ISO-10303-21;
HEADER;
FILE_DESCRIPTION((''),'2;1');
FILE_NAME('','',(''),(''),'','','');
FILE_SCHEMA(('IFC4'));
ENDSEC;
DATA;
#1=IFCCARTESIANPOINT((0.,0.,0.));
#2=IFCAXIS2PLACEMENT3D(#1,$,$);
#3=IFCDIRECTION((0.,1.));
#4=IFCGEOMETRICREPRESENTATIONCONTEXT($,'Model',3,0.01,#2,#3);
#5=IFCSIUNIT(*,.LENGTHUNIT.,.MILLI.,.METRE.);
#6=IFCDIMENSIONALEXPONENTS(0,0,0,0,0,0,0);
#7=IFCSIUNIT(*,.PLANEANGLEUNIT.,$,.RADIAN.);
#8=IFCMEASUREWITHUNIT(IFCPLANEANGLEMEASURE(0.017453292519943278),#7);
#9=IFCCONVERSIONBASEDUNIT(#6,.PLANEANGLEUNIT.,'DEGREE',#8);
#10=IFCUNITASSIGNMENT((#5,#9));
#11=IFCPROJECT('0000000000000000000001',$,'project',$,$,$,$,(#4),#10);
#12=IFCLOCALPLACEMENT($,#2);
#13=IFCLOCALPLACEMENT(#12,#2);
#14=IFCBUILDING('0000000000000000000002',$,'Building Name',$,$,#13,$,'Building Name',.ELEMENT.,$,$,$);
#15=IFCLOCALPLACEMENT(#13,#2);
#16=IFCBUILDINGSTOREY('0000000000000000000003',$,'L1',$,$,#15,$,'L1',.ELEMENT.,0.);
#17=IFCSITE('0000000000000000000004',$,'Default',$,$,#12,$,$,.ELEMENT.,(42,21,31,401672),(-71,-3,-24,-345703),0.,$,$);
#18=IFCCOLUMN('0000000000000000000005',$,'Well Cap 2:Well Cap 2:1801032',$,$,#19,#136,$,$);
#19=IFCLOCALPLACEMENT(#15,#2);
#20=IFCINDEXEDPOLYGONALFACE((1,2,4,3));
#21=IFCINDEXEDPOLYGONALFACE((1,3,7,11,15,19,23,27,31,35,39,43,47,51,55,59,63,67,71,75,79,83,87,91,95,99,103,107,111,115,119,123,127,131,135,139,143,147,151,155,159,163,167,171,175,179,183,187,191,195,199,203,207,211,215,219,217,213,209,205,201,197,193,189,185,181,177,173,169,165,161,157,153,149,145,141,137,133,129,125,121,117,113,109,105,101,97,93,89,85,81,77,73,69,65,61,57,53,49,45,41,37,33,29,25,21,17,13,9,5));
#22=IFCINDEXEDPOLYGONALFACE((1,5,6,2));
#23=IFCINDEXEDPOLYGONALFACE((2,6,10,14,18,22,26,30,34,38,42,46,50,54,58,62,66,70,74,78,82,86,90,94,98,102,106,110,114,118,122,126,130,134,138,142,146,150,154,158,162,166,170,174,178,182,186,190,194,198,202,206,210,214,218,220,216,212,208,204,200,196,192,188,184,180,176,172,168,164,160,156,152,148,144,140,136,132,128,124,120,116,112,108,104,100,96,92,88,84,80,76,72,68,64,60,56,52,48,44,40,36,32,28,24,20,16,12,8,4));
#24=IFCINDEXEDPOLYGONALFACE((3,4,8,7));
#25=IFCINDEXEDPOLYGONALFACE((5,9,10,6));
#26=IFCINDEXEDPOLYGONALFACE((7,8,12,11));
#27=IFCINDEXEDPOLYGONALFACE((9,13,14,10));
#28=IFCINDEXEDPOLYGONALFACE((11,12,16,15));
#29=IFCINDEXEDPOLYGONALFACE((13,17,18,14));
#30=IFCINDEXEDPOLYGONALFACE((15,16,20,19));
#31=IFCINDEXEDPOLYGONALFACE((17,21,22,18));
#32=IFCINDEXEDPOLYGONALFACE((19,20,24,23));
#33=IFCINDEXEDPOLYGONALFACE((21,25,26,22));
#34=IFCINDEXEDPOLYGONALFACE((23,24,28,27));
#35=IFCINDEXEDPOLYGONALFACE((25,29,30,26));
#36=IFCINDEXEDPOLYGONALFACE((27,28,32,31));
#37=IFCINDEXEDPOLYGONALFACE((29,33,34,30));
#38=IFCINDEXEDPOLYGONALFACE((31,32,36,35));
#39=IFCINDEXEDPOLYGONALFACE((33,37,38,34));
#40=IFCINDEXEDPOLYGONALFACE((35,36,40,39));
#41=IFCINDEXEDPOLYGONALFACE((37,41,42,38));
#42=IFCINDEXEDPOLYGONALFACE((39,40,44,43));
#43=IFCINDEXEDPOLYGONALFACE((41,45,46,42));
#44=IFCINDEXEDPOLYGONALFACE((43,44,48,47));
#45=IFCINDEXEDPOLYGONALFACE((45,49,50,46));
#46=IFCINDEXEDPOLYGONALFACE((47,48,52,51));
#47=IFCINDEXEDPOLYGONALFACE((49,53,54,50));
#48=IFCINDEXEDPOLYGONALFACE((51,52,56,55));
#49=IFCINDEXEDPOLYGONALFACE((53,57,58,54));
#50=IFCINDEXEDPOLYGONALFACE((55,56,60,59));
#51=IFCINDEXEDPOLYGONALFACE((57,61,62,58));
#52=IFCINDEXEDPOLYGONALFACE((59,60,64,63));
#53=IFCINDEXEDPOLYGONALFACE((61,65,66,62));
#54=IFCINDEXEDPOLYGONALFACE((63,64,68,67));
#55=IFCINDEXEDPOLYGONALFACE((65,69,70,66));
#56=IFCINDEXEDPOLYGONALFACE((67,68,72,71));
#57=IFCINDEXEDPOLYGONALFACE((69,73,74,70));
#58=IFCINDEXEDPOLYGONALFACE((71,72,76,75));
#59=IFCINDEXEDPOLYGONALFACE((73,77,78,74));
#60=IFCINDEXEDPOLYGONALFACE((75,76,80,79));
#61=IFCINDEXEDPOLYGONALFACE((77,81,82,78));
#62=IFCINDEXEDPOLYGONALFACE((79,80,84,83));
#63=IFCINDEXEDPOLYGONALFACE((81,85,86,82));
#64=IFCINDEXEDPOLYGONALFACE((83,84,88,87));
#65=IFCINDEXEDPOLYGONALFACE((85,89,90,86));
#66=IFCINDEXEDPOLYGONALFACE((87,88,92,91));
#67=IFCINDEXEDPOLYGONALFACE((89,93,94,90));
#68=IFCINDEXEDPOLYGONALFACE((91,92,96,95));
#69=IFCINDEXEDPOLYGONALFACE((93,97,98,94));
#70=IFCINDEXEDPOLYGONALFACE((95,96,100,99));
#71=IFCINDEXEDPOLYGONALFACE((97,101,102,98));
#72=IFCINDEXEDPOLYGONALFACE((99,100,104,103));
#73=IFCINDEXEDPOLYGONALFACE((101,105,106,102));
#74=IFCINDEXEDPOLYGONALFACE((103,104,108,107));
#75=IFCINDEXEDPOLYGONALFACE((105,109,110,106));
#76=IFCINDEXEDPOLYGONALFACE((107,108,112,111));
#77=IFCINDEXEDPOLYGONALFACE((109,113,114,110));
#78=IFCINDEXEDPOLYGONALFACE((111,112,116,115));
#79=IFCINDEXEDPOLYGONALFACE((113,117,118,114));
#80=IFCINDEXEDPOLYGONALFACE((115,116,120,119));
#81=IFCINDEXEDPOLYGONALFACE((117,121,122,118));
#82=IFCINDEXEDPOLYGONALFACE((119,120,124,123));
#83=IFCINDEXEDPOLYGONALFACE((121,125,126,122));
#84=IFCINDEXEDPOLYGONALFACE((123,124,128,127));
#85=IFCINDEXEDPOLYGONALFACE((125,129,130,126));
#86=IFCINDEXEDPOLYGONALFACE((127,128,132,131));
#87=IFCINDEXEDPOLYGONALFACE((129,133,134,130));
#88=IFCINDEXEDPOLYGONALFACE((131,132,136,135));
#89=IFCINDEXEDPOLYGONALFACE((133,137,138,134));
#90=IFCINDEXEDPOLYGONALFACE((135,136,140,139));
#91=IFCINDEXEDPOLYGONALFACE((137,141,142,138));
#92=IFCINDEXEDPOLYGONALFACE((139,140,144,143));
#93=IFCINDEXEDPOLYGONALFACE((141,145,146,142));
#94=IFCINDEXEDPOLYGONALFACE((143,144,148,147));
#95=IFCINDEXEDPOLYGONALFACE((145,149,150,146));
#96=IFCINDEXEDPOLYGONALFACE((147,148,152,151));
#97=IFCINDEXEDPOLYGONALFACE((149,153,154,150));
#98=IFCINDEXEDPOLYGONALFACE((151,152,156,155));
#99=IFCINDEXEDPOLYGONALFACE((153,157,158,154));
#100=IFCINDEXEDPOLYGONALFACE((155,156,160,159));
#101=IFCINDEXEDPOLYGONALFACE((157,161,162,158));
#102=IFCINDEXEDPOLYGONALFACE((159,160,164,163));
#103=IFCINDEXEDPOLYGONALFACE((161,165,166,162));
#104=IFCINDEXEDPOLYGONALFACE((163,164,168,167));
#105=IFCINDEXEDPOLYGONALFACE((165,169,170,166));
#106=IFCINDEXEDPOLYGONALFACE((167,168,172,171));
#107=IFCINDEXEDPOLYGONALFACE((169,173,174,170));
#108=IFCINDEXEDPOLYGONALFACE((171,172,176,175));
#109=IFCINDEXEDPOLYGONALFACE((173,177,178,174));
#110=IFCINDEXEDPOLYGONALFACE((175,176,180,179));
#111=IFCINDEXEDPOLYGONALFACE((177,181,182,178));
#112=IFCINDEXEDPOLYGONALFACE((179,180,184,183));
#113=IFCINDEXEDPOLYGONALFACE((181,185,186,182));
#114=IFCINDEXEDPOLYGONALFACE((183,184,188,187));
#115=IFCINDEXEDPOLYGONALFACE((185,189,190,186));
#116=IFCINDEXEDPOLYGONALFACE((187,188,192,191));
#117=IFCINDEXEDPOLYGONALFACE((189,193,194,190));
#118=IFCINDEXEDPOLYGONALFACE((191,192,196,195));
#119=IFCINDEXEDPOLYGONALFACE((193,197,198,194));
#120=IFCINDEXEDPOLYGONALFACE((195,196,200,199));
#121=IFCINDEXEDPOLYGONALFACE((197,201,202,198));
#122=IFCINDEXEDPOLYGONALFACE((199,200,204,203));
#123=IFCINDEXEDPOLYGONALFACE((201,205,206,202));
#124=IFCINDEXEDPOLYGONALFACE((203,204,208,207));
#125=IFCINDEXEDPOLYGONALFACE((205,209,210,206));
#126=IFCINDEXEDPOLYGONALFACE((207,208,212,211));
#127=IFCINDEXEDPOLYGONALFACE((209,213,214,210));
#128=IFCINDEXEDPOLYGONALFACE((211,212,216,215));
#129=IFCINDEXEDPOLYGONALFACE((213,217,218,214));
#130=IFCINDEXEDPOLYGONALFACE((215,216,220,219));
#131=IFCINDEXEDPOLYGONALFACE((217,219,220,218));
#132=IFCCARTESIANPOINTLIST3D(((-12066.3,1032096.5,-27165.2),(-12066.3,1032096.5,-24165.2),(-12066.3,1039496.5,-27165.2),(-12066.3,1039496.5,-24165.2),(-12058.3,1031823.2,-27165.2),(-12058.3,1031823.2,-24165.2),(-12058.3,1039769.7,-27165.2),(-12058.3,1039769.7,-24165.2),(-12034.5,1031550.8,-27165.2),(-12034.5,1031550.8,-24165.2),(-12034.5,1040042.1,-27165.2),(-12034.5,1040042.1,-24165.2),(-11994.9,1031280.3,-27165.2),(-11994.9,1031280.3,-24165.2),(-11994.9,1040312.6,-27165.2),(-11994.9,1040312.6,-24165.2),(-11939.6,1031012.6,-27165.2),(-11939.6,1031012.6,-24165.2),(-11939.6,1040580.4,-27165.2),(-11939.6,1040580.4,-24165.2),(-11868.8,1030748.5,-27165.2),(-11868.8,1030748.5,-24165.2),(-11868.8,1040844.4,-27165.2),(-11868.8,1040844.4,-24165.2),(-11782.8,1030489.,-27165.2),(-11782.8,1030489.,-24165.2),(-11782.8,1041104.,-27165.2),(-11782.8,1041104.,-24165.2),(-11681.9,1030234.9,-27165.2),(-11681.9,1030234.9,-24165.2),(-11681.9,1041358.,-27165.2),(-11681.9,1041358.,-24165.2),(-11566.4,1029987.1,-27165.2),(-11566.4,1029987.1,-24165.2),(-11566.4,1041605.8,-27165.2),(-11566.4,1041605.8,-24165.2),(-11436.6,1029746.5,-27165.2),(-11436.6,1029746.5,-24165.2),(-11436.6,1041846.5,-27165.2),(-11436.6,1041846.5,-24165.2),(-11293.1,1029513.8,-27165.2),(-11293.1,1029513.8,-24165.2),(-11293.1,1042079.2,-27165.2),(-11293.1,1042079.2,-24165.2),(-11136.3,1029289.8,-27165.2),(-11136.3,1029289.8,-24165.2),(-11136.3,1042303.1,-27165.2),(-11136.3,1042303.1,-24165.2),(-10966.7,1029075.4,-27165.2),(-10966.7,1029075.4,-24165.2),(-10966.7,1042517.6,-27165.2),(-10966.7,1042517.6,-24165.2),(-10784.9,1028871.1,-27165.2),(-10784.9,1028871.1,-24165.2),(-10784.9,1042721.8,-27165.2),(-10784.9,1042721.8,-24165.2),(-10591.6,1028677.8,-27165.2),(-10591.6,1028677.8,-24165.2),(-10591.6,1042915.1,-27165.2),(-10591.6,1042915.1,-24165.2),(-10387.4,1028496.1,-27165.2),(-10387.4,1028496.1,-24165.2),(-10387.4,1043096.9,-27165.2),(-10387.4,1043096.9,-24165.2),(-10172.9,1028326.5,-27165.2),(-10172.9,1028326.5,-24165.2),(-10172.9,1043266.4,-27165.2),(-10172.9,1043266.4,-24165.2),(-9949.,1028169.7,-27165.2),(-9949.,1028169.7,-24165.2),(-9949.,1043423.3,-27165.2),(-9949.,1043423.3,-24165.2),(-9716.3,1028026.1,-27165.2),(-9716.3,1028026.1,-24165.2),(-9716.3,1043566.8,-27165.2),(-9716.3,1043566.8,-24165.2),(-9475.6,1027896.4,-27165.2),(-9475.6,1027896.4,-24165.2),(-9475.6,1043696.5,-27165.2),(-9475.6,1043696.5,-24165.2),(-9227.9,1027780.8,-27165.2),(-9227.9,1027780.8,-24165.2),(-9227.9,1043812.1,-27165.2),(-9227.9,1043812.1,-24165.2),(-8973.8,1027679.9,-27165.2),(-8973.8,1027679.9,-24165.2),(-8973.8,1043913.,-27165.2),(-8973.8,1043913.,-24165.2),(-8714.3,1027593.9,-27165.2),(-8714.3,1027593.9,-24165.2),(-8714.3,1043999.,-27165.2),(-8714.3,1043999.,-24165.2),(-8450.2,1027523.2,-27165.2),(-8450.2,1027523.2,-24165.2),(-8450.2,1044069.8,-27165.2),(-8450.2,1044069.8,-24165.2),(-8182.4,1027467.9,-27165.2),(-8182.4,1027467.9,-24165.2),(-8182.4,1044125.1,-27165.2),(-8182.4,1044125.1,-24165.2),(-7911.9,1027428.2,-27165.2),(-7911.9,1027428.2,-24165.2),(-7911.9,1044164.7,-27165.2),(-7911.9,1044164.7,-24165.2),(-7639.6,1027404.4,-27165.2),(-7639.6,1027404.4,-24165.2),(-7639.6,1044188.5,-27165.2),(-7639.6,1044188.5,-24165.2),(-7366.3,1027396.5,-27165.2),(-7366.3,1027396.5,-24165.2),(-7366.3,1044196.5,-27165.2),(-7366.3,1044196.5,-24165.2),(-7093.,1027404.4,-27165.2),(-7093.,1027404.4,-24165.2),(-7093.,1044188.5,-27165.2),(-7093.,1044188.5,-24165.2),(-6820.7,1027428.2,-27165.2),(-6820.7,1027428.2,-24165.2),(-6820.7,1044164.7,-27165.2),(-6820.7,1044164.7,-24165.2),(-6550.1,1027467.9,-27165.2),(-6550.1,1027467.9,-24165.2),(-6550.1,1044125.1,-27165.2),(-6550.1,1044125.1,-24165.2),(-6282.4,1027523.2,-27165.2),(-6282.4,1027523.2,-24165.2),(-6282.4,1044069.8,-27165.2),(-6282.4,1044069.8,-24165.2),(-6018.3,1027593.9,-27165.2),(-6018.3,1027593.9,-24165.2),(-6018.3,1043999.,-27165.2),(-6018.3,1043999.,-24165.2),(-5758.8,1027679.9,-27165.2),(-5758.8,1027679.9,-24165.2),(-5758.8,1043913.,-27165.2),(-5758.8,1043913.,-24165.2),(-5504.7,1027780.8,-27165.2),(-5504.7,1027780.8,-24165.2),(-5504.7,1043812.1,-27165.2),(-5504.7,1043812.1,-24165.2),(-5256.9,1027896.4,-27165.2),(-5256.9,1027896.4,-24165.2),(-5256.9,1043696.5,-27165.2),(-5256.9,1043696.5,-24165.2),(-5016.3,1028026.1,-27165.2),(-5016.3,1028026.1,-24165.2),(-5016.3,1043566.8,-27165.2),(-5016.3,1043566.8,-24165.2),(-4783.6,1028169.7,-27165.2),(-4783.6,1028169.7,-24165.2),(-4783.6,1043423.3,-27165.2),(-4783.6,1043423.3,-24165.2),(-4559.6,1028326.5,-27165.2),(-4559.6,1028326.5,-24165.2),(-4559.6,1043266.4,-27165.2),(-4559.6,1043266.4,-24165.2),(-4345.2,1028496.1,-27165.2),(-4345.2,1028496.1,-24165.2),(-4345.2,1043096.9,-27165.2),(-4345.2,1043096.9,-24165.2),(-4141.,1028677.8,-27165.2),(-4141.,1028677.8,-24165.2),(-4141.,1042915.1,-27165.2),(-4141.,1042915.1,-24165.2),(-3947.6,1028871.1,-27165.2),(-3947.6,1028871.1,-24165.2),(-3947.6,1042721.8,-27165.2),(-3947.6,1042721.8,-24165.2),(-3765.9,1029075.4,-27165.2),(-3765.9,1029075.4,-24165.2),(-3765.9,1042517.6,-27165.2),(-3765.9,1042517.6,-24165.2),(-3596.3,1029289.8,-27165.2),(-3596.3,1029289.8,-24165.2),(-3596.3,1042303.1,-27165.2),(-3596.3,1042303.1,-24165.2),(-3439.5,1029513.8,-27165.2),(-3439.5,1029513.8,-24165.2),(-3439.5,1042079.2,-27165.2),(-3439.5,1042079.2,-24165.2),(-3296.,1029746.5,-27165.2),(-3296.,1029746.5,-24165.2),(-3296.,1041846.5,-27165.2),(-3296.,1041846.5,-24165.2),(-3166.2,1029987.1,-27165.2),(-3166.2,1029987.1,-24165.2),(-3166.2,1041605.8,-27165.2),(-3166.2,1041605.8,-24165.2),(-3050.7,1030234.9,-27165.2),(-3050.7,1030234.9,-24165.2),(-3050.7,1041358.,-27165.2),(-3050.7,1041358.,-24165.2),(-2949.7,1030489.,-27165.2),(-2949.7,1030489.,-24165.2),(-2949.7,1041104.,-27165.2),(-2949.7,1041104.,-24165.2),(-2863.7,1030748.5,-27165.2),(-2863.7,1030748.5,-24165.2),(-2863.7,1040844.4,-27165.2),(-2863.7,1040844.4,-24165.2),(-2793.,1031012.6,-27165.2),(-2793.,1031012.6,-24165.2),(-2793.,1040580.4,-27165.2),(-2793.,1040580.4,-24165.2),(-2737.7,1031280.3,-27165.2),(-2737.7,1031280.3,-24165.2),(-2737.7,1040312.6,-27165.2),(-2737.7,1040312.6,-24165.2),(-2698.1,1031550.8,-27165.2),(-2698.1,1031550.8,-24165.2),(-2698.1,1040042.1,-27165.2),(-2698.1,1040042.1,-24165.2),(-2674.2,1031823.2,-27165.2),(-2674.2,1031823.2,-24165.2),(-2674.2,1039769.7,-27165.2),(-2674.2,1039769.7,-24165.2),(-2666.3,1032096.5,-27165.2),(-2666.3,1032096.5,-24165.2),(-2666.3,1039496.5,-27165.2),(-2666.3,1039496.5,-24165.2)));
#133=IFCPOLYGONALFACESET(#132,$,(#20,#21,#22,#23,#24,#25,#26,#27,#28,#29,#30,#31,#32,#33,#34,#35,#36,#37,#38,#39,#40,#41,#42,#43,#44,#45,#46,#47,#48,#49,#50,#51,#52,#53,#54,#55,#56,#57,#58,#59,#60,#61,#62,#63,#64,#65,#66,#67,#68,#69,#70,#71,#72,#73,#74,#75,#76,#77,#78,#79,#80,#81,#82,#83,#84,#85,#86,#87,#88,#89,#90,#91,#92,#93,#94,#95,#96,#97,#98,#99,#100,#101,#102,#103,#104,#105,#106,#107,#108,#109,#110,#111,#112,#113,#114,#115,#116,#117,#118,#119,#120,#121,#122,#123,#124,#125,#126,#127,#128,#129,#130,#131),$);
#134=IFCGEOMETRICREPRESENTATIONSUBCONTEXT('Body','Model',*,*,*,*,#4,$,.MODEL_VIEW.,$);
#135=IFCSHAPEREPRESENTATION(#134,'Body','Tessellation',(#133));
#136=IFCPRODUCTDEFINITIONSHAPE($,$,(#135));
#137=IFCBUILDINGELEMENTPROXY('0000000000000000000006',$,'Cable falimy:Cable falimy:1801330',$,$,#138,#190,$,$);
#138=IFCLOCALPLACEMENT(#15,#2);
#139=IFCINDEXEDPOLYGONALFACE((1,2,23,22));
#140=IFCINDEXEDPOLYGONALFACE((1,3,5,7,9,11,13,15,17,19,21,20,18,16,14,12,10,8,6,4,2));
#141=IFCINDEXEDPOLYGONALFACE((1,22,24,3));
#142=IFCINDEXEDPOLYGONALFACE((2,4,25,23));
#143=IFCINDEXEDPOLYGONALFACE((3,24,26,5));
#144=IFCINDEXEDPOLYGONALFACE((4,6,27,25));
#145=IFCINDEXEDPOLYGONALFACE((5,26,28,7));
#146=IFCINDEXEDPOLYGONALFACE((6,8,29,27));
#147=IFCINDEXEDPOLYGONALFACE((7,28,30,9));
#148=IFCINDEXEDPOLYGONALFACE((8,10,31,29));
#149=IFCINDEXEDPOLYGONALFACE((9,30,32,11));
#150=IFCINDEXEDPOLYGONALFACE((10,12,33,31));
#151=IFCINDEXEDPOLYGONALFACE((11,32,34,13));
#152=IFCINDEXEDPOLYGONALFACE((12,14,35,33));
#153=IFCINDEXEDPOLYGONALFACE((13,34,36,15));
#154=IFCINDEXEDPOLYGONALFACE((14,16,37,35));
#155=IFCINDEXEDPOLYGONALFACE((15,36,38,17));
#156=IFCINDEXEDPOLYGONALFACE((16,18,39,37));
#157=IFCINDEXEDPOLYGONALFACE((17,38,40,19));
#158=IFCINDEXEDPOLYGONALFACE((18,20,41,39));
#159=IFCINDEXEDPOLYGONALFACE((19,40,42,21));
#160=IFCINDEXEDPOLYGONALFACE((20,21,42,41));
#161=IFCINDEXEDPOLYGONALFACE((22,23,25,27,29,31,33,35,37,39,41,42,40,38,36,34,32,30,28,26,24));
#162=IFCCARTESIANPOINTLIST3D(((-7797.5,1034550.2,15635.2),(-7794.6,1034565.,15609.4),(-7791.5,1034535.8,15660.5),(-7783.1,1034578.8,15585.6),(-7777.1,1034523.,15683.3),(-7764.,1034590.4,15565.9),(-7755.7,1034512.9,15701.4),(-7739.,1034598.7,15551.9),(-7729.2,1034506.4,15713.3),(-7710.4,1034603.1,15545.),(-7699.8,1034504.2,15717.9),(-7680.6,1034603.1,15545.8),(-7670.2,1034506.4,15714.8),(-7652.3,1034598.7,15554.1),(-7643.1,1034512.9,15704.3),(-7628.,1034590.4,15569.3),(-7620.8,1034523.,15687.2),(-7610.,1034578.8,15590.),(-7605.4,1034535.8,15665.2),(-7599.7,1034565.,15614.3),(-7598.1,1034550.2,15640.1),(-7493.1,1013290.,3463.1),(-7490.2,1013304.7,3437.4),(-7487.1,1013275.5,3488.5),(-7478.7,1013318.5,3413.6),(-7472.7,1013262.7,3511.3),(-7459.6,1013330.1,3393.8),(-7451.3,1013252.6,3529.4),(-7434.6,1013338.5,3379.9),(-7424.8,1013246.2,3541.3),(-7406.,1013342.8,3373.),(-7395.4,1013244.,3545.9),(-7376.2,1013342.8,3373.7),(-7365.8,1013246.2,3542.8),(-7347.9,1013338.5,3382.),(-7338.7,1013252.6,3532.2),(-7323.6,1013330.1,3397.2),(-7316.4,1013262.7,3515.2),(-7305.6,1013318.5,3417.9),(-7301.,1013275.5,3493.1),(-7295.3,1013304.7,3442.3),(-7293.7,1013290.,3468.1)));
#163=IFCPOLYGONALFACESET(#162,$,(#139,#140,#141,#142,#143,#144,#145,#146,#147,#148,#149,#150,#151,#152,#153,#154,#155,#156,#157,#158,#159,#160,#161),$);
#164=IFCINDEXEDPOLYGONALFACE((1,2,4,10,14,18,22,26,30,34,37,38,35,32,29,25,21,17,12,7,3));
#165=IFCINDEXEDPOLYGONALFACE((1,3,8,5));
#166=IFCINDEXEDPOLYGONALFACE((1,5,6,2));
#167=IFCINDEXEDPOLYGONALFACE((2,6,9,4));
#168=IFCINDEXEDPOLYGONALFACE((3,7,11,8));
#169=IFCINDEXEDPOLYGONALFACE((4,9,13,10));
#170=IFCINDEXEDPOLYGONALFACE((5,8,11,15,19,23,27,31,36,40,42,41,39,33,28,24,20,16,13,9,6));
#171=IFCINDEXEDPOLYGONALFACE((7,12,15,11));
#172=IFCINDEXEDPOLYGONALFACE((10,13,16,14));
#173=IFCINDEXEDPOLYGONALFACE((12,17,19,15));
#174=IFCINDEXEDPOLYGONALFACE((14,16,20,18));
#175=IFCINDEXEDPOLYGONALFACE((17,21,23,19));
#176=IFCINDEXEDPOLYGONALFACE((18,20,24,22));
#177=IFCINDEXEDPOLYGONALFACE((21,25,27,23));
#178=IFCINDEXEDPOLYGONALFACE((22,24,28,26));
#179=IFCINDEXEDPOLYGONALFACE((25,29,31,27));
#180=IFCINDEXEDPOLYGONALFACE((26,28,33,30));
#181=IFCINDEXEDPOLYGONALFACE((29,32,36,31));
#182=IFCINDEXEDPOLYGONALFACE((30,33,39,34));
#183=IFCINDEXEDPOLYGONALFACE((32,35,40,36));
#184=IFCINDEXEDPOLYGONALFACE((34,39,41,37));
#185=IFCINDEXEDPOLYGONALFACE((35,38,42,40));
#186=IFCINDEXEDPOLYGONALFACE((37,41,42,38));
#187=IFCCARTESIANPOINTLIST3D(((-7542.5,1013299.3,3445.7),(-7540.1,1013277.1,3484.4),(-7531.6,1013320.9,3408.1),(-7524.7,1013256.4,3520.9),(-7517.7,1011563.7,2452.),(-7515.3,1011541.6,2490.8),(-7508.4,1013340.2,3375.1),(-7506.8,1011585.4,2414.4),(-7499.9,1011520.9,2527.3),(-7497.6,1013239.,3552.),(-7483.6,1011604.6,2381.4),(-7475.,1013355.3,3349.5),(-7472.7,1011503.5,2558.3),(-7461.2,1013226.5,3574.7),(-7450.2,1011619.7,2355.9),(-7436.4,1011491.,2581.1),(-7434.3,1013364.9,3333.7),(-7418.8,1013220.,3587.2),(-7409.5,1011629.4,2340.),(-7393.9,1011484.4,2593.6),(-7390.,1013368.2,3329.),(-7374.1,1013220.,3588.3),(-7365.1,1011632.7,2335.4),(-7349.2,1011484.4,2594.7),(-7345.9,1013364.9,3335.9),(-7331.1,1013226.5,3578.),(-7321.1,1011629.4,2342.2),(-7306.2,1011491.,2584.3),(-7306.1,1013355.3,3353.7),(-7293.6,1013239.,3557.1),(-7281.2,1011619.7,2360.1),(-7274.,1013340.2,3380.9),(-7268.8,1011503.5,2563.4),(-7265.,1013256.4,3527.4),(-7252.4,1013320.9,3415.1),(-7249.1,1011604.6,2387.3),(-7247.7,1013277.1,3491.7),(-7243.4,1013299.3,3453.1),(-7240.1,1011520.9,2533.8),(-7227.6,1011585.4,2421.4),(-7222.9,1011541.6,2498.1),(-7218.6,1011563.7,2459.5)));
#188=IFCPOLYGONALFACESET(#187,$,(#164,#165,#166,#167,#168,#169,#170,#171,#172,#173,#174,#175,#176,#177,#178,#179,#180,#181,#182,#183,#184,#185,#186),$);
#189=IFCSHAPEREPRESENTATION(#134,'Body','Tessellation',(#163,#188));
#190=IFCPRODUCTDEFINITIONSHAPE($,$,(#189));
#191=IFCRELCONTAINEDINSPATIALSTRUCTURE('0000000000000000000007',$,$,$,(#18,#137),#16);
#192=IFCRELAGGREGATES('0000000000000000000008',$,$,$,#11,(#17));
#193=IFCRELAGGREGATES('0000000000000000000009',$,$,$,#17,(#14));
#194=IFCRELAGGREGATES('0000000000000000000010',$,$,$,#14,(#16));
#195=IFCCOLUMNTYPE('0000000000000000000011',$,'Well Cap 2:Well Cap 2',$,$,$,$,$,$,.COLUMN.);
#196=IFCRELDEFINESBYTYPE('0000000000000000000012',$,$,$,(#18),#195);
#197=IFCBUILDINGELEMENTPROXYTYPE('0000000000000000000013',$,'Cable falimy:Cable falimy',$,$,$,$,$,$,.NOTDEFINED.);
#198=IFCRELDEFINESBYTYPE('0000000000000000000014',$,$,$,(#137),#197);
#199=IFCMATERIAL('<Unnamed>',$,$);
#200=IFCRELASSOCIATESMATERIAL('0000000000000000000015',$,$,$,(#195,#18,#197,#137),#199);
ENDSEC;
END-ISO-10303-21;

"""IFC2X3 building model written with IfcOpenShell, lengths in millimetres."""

from ifc_helpers import new_model, entity, si_unit, converted_unit, direction, frame, frame_2d, origin, place, context, subcontext, project, spatial, polyline, circle_curve, parameter, trimmed, segment, composite_curve, circle, outline, extrude, source, transform, mapped, material, type_object, type_shapes, element, save


model = new_model("IFC2X3")

# Units and contexts
model_context = context("Model", 3, precision=0.01, world=origin(), true_north=direction((0.0, 1.0)))
body_context = subcontext(model_context, "Body", "Model", "MODEL_VIEW")
ifc_project = project(units=[si_unit("LENGTHUNIT", "METRE", prefix="MILLI"), converted_unit("PLANEANGLEUNIT", "DEGREE", entity("IfcPlaneAngleMeasure", 0.017453292519943278), si_unit("PLANEANGLEUNIT", "RADIAN"), dimensions=[0, 0, 0, 0, 0, 0, 0])], contexts=[model_context])

# Site, building, storey
site_placement = place(None, origin())
site = spatial("IfcSite", under=ifc_project, at=site_placement, Name="Default", CompositionType="ELEMENT", RefLatitude=(42, 21, 31, 401672), RefLongitude=(-71, -3, -24, -345703), RefElevation=0.0)
building_placement = place(site_placement, origin())
building = spatial("IfcBuilding", under=site, at=building_placement, Name="Building Name", LongName="Building Name", CompositionType="ELEMENT")
storey_placement = place(building_placement, origin())
storey = spatial("IfcBuildingStorey", under=building, at=storey_placement, Name="L1", LongName="L1", CompositionType="ELEMENT", Elevation=0.0)

# Column
ifc_material = material(Name="<Unnamed>")
column_type_1 = type_object("IfcColumnType", Name="Well Cap 2:Well Cap 2", PredefinedType="COLUMN", material=ifc_material)
shared_shape_1 = source(origin(), body_context, "Body", "SweptSolid", [
    extrude(outline(composite_curve([segment(polyline([(-3700.0, -4700.0), (3700.0, -4700.0)]), True, "CONTINUOUS"), segment(trimmed(circle_curve(frame_2d((3700.0, 0.0), x_axis=(0.0, -1.0)), 4700.0), [parameter(0.0)], [parameter(180.0)], True, "PARAMETER"), True, "CONTINUOUS"), segment(polyline([(3700.0, 4700.0), (-3700.0, 4700.0)]), True, "CONTINUOUS"), segment(trimmed(circle_curve(frame_2d((-3700.0, 0.0), x_axis=(0.0, 1.0)), 4700.0), [parameter(0.0)], [parameter(180.0)], True, "PARAMETER"), True, "CONTINUOUS")], self_intersect=False)), frame((8064.3, 0.0, 0.0), z_axis=(0.0, 0.0, 1.0), x_axis=(0.0, -1.0, 0.0)), (0.0, 0.0, 1.0), 3000.0),
])
type_shapes(column_type_1, [shared_shape_1])
column_1_placement = place(storey_placement, frame((-15430.5, 1035796.5, -27165.2)))
element("IfcColumn", 1, at=column_1_placement, inside=storey, type_object=column_type_1, material=ifc_material, Name="Well Cap 2:Well Cap 2:1801032", context=body_context, shape_type="MappedRepresentation", body=[
    mapped(shared_shape_1, transform((0.0, 0.0, 0.0), scale=1.0)),
])

# Building element proxy
building_element_proxy_type_1 = type_object("IfcBuildingElementProxyType", Name="Cable falimy:Cable falimy", PredefinedType="NOTDEFINED", material=ifc_material)
shared_shape_2 = source(origin(), body_context, "Body", "SweptSolid", [
    extrude(circle(Radius=100.0, at=frame_2d((0.0, 0.0), x_axis=(1.0, 0.0))), frame((0.0, 0.0, 0.0), z_axis=(0.867765, 0.0, 0.496974), x_axis=(-0.496974, 0.0, 0.867765)), (0.0, 0.0, 1.0), 24500.0),
    extrude(circle(Radius=150.0, at=frame_2d((0.0, 0.0), x_axis=(1.0, 0.0))), frame((-1735.5, 0.0, -993.9), z_axis=(0.867765, 0.0, 0.496974), x_axis=(0.496974, 0.0, -0.867765)), (0.0, 0.0, 1.0), 2000.0),
])
type_shapes(building_element_proxy_type_1, [shared_shape_2])
proxy_1_placement = place(storey_placement, frame((-7393.2, 1013293.7, 3459.1), z_axis=(-0.025001, 0.0, 0.999687), x_axis=(0.0, 1.0, 0.0)))
element("IfcBuildingElementProxy", 2, at=proxy_1_placement, inside=storey, type_object=building_element_proxy_type_1, material=ifc_material, Name="Cable falimy:Cable falimy:1801330", context=body_context, shape_type="MappedRepresentation", body=[
    mapped(shared_shape_2, transform((0.0, 0.0, 0.0), scale=1.0)),
])

save(model, "model.ifc")
